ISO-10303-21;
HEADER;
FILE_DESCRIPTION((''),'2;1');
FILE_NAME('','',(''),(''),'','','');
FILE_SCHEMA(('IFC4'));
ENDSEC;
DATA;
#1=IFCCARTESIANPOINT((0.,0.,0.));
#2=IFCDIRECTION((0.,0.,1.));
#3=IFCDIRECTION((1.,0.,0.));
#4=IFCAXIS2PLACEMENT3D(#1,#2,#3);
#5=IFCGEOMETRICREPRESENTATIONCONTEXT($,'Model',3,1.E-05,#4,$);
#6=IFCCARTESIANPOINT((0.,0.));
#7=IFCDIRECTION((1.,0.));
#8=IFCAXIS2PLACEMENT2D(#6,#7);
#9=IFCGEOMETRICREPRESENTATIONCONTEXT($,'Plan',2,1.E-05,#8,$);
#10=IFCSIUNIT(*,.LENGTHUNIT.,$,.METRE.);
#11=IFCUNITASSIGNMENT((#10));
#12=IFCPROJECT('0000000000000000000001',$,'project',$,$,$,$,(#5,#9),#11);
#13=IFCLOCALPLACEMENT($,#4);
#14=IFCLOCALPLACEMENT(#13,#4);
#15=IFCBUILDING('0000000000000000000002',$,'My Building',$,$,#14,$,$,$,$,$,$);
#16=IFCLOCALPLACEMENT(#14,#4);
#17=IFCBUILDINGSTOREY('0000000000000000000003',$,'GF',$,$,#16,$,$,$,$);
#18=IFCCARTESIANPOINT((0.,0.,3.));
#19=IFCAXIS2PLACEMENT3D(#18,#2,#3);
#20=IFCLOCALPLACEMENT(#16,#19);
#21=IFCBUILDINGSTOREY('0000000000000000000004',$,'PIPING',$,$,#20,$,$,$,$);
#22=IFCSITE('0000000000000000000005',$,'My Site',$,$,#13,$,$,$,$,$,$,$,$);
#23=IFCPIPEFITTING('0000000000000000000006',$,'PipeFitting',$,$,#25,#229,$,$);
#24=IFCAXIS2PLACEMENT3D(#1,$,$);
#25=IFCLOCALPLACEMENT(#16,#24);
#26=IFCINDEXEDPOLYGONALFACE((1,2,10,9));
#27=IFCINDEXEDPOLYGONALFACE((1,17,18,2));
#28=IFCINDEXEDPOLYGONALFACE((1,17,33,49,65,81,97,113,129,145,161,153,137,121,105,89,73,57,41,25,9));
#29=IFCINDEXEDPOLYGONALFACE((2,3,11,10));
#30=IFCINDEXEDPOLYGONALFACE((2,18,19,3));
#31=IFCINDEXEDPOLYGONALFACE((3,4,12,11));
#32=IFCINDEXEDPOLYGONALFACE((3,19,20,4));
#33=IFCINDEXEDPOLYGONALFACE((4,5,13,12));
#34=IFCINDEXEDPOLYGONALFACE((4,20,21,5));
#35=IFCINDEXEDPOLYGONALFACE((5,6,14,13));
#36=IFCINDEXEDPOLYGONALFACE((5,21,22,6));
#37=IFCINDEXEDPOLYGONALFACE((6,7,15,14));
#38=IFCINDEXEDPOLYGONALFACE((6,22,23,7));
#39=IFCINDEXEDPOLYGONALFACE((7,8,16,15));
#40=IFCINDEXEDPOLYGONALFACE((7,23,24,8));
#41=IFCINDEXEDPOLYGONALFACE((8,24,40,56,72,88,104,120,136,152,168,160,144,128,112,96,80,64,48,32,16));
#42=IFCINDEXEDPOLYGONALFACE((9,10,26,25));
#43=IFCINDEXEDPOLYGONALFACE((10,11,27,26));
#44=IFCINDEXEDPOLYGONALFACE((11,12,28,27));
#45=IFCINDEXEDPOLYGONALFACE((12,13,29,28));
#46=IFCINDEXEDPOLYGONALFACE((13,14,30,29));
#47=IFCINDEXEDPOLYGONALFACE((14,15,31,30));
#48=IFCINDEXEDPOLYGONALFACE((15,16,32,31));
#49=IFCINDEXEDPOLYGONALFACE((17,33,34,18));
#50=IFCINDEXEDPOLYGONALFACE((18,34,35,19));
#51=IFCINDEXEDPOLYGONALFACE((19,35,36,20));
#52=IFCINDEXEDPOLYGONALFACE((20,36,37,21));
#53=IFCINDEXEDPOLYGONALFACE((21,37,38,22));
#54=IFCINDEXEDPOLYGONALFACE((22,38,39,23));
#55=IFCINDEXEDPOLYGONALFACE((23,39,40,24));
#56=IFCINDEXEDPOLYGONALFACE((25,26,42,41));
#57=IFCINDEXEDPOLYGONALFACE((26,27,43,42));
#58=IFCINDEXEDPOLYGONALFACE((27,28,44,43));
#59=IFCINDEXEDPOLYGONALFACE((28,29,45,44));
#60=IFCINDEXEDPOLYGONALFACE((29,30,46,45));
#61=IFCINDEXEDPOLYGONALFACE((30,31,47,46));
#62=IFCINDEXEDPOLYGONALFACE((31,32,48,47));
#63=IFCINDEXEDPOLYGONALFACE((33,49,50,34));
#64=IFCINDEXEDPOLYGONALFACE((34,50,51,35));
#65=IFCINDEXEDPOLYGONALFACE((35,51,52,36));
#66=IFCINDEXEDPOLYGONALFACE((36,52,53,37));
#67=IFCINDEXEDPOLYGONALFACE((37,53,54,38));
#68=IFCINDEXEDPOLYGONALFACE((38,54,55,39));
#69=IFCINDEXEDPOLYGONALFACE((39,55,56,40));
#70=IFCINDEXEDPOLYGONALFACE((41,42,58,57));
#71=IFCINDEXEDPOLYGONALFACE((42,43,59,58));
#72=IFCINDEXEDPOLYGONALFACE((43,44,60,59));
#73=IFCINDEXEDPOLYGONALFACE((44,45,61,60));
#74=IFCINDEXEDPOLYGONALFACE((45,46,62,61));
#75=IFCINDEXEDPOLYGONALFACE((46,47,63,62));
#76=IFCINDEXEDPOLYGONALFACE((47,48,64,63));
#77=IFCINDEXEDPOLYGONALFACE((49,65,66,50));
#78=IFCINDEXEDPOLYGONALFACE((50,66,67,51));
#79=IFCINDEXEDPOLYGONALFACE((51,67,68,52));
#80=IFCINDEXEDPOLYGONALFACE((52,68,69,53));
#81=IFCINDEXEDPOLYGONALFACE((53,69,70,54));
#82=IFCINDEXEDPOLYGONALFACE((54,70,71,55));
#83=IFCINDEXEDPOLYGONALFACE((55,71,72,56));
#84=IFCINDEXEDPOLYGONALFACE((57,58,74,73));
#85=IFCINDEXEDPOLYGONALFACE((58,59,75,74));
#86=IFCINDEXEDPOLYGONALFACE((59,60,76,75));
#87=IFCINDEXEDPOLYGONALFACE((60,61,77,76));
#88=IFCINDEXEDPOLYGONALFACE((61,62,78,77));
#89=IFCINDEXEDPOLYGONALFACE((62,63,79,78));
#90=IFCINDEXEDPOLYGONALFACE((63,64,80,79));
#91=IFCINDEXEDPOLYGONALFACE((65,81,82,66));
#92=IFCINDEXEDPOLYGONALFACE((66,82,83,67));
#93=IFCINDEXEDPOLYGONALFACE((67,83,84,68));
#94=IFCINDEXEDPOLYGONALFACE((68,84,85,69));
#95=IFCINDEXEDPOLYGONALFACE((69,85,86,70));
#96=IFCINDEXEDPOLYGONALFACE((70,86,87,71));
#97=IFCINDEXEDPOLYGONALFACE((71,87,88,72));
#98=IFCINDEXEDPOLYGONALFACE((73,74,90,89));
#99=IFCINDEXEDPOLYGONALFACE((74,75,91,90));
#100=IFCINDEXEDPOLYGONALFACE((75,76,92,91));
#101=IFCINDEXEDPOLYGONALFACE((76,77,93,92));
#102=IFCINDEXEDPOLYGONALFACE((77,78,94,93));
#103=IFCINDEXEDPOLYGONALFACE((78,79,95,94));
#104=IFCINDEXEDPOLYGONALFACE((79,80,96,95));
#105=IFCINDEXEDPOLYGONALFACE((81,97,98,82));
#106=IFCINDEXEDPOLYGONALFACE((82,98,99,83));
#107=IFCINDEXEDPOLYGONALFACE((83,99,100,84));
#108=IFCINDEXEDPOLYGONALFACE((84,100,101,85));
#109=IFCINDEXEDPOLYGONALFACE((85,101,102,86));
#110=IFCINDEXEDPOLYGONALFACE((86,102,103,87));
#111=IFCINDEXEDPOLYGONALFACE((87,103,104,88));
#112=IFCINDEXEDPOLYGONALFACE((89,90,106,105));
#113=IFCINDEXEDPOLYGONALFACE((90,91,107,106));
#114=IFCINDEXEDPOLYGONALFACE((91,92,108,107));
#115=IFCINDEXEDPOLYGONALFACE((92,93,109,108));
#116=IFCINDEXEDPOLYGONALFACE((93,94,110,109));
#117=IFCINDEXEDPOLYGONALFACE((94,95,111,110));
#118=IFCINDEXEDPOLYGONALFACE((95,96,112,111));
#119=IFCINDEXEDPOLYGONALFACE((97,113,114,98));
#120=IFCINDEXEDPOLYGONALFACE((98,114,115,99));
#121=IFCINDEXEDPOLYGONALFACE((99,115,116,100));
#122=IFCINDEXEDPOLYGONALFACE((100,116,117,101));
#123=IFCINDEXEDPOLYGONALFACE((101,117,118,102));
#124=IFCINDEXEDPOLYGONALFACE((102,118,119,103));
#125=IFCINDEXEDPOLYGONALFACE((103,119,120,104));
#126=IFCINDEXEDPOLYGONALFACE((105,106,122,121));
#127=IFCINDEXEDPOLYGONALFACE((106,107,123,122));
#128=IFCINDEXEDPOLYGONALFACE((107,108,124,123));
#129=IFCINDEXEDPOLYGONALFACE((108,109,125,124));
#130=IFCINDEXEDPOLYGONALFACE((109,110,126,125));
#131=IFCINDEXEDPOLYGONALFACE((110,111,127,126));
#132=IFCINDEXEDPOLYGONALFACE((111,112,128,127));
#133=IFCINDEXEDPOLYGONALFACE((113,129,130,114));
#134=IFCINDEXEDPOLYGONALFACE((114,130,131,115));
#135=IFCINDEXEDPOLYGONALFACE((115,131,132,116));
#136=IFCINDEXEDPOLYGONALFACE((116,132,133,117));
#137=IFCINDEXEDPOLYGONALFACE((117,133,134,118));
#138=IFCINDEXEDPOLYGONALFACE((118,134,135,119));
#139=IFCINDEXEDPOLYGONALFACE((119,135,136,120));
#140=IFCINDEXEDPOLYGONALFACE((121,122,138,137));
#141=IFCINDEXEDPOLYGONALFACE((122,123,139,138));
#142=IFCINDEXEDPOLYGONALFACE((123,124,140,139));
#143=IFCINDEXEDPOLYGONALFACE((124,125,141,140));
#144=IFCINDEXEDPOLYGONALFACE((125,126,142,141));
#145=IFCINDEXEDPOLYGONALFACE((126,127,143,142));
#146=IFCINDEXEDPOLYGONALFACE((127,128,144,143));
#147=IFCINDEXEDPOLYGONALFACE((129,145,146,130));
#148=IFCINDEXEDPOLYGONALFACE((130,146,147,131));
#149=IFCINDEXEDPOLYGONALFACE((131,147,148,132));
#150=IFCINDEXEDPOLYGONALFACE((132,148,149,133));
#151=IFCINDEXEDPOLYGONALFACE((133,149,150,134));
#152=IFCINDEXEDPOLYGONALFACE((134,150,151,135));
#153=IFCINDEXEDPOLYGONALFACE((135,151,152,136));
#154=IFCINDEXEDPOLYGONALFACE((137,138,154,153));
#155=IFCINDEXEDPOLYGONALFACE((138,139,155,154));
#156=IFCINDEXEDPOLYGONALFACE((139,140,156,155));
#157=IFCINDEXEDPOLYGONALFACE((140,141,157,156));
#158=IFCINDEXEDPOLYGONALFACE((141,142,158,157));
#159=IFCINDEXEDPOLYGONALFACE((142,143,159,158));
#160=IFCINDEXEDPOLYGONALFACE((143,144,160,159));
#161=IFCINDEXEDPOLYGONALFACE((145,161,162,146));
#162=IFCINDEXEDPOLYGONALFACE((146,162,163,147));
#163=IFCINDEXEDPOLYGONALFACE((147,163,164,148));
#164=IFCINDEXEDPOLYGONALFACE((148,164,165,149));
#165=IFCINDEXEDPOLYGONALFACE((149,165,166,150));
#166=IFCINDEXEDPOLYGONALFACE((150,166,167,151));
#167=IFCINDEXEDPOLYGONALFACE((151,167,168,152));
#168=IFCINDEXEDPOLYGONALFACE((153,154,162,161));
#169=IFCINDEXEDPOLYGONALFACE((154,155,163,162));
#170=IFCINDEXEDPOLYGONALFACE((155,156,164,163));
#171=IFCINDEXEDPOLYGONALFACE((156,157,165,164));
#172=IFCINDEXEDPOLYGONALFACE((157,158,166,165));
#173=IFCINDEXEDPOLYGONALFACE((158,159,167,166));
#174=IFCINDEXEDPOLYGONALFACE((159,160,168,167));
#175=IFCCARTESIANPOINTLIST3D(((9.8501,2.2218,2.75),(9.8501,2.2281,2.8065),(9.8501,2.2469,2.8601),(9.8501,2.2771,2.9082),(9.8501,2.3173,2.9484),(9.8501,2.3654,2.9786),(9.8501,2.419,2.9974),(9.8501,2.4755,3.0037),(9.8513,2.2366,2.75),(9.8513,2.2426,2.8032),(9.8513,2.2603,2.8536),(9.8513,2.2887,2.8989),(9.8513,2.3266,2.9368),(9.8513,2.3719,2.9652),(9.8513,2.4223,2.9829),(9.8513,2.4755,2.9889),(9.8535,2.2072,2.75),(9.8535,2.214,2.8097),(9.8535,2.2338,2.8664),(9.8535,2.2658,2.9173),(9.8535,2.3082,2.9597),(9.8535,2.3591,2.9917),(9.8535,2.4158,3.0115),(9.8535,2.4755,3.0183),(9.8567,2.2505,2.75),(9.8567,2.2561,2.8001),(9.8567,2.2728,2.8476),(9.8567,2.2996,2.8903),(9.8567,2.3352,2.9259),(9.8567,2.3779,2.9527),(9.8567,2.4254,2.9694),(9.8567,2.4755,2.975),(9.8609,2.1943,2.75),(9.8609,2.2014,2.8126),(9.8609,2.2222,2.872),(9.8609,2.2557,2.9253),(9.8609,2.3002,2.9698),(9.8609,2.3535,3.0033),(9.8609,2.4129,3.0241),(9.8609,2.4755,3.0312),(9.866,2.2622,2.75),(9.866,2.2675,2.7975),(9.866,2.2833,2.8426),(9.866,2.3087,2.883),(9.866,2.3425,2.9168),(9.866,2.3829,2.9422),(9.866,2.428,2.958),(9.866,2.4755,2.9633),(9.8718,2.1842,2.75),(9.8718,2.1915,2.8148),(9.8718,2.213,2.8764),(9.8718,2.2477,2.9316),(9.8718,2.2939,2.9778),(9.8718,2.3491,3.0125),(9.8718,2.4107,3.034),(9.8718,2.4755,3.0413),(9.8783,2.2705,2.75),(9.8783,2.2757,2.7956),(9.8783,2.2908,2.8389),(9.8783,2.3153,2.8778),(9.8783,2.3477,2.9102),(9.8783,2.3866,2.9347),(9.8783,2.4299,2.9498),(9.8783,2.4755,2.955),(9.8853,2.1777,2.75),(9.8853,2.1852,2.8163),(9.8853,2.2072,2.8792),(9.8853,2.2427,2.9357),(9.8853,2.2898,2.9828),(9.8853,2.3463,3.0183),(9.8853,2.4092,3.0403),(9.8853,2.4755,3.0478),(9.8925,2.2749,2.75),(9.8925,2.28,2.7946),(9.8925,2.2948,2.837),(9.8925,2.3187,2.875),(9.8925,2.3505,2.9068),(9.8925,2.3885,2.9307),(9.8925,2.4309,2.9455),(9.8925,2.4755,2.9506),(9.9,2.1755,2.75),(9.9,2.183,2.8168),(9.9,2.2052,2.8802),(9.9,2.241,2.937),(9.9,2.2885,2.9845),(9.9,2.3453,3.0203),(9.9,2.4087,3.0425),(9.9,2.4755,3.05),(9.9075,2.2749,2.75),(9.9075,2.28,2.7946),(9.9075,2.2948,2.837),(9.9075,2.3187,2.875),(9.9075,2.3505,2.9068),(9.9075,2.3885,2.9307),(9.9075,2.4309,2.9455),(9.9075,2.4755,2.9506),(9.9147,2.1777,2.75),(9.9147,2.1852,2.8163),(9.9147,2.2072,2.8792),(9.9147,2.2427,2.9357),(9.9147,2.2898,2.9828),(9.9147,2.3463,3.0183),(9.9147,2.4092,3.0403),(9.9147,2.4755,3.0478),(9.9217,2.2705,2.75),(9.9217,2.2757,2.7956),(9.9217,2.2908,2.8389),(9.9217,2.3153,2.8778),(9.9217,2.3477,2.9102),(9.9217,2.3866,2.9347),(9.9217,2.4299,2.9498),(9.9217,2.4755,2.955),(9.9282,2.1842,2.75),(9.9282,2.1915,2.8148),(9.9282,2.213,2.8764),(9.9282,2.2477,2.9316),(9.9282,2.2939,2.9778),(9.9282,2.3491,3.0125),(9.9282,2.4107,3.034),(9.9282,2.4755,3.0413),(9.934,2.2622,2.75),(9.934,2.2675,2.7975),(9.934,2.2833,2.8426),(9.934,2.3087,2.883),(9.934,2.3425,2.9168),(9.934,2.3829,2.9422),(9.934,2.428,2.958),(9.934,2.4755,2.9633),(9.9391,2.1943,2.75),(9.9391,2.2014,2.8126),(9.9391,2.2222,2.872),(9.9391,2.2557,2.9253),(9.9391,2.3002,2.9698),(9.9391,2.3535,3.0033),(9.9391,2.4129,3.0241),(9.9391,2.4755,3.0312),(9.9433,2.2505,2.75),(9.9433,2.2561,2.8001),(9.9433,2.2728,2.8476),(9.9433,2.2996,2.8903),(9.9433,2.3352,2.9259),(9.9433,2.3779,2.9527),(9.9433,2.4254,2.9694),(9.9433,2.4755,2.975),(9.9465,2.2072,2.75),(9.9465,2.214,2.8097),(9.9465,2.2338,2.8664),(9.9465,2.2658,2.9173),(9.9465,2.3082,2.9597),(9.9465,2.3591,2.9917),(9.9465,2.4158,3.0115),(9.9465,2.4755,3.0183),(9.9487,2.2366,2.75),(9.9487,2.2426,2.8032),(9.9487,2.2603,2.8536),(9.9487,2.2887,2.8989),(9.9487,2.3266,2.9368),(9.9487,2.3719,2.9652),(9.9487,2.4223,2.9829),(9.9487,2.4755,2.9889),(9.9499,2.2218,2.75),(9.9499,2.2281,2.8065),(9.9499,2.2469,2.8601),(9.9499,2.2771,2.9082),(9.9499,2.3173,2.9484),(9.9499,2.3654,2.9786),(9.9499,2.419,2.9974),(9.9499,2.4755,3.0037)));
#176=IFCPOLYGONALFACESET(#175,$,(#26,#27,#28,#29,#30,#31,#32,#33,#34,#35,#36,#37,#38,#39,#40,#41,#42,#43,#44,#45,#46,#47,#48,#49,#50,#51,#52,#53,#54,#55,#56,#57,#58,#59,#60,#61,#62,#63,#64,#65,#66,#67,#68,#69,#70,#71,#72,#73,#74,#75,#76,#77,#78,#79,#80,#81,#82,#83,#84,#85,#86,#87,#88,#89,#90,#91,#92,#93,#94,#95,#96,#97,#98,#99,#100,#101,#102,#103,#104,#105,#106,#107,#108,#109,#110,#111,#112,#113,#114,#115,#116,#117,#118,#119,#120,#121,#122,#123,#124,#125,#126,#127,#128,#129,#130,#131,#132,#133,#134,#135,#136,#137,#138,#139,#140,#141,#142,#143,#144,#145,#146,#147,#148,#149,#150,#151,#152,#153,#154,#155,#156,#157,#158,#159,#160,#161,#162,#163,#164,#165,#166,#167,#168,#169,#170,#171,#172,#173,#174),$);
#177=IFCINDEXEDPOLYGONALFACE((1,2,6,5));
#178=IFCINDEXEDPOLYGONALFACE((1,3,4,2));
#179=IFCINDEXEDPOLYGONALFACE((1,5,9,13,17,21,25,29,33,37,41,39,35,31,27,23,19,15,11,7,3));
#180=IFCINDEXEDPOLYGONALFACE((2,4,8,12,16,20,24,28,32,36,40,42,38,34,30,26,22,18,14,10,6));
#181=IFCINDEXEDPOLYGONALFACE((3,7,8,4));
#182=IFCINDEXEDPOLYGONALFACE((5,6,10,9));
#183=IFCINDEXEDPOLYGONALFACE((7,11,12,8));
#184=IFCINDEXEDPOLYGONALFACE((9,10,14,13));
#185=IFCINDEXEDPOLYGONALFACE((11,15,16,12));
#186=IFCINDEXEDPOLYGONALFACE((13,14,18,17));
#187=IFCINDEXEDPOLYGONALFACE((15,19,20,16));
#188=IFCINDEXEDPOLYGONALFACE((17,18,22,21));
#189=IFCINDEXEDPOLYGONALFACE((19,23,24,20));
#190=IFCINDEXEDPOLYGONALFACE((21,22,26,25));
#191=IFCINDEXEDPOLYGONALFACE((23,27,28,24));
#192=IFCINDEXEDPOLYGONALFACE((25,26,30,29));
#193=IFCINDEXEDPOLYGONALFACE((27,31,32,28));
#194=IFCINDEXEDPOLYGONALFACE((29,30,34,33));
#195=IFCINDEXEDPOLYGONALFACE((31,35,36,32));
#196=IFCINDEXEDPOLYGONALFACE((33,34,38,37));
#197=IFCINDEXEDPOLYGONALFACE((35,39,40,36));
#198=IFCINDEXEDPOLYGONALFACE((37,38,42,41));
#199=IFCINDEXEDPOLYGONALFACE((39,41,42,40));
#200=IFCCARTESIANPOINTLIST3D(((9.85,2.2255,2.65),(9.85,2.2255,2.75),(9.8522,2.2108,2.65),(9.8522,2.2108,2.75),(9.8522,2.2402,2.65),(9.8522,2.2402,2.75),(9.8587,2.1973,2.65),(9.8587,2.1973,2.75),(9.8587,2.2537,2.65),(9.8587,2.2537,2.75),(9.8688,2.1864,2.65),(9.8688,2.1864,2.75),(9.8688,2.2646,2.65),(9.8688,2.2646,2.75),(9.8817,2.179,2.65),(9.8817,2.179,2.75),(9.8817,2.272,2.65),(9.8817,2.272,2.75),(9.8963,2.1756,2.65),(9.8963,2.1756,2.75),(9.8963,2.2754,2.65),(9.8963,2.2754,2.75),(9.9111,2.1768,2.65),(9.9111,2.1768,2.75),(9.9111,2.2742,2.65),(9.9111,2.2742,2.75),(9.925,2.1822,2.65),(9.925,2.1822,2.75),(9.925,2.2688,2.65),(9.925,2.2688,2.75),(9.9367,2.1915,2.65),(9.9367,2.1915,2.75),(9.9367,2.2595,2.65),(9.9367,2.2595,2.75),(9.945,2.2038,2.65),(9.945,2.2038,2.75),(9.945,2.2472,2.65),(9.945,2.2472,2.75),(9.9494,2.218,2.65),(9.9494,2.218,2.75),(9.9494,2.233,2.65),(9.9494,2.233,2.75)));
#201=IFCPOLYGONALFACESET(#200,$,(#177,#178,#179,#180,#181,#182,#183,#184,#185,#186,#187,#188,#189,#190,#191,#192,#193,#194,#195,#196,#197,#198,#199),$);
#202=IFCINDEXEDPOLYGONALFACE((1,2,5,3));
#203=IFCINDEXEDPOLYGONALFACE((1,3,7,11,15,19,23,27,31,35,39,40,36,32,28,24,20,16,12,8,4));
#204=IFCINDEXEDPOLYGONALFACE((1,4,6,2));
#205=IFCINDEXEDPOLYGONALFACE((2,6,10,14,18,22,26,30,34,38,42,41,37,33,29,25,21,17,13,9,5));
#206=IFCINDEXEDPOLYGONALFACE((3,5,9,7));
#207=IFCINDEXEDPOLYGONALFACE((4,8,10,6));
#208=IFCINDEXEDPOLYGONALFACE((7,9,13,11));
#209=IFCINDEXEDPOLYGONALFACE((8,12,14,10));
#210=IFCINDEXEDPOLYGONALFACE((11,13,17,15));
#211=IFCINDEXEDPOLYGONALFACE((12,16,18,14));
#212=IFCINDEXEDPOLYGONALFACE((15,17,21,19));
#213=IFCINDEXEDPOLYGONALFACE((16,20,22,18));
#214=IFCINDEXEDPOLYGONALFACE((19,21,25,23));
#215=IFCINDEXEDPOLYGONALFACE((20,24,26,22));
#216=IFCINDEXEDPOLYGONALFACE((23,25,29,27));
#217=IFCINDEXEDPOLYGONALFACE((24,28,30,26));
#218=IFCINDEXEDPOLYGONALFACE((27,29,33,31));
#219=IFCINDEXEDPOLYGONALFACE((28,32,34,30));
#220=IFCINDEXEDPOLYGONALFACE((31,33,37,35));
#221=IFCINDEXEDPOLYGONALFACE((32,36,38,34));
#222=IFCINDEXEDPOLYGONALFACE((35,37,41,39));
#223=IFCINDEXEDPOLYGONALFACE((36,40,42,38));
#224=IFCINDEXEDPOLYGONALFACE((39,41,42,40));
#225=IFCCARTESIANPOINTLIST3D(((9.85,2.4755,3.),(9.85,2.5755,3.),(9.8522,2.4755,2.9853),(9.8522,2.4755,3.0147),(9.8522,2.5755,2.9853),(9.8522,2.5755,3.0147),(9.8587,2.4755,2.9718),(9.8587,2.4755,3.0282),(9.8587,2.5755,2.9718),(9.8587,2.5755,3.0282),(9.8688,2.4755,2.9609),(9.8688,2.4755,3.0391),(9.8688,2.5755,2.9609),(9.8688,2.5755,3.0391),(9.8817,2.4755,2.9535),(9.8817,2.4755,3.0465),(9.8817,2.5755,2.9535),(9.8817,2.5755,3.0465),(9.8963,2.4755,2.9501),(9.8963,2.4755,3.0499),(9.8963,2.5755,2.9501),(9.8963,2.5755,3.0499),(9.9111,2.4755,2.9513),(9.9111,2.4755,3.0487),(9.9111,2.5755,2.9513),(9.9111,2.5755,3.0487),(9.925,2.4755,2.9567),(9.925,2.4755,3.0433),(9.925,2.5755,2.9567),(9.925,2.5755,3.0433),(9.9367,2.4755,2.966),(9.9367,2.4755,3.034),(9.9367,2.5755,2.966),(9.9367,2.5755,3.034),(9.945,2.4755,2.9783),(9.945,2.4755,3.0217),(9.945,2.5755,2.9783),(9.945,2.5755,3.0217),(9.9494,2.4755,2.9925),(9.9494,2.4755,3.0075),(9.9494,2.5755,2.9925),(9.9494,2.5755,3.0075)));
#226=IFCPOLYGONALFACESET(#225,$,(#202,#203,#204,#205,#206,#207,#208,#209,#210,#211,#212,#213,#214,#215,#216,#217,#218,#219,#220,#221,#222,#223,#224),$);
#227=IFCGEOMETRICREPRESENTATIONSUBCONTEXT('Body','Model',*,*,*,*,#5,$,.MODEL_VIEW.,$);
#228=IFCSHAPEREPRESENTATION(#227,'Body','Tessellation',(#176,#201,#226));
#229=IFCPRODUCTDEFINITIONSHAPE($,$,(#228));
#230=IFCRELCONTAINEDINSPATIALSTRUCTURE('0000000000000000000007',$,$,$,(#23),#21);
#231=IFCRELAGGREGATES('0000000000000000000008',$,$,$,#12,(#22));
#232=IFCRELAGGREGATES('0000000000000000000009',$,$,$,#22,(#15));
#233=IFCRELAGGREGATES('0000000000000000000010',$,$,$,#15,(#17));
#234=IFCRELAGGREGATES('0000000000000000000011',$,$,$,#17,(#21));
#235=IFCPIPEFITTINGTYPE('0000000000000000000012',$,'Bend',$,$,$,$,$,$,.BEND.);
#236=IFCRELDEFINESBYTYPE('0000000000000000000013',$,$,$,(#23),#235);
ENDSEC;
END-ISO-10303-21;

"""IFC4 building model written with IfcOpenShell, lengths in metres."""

from ifc_helpers import new_model, entity, si_unit, frame, origin_with_axes, origin_2d_with_axis, place, context, subcontext, project, spatial, circle, extrude, source, transform, mapped, type_object, type_shapes, element, save


model = new_model("IFC4")

# Units and contexts
model_context = context("Model", 3, precision=1e-05, world=origin_with_axes())
plan_context = context("Plan", 2, precision=1e-05, world=origin_2d_with_axis())
body_context = subcontext(model_context, "Body", "Model", "MODEL_VIEW")
ifc_project = project(units=[si_unit("LENGTHUNIT", "METRE")], contexts=[model_context, plan_context])

# Site, building, storeys
site_placement = place(None, origin_with_axes())
site = spatial("IfcSite", under=ifc_project, at=site_placement, Name="My Site")
building_placement = place(site_placement, origin_with_axes())
building = spatial("IfcBuilding", under=site, at=building_placement, Name="My Building")
storey_1_placement = place(building_placement, origin_with_axes())
storey_1 = spatial("IfcBuildingStorey", under=building, at=storey_1_placement, Name="GF")
storey_2_placement = place(storey_1_placement, frame((0.0, 0.0, 3.0), z_axis=(0.0, 0.0, 1.0), x_axis=(1.0, 0.0, 0.0)))
storey_2 = spatial("IfcBuildingStorey", under=storey_1, at=storey_2_placement, Name="PIPING")

# Pipe fitting
pipe_fitting_type = type_object("IfcPipeFittingType", Name="Bend", PredefinedType="BEND")
shared_shape = source(origin_with_axes(), body_context, "Body", "SolidModel", [
    entity("IfcSweptDiskSolid", entity("IfcIndexedPolyCurve", entity("IfcCartesianPointList3D", [[0.0, 0.0, -0.1], [0.0, 0.0732, -0.2768], [0.0, 0.25, -0.35]]), [entity("IfcArcIndex", [1, 2, 3])]), 0.05),
    extrude(circle(Radius=0.05), origin_with_axes(), (0.0, 0.0, -1.0), 0.1),
    extrude(circle(Radius=0.05), frame((0.0, 0.25, -0.35), z_axis=(0.0, 1.0, 0.0), x_axis=(1.0, 0.0, 0.0)), (0.0, 0.0, 1.0), 0.1),
])
type_shapes(pipe_fitting_type, [shared_shape])
for number, where, z_axis, x_axis, name in (
    (1, (9.9, 2.2255, -0.35), (0.0, 0.0, -1.0), (-1.0, 0.0, 0.0), "PipeFitting"),
):
    element("IfcPipeFitting", number, at=place(storey_2_placement, frame(where, z_axis=z_axis, x_axis=x_axis)), inside=storey_2, type_object=pipe_fitting_type, Name=name, context=body_context, shape_type="MappedRepresentation", body=[
        mapped(shared_shape, transform((0.0, 0.0, 0.0), x_axis=(1.0, 0.0, 0.0), y_axis=(0.0, 1.0, 0.0), z_axis=(0.0, 0.0, 1.0), scale=1.0)),
    ])

save(model, "model.ifc")
